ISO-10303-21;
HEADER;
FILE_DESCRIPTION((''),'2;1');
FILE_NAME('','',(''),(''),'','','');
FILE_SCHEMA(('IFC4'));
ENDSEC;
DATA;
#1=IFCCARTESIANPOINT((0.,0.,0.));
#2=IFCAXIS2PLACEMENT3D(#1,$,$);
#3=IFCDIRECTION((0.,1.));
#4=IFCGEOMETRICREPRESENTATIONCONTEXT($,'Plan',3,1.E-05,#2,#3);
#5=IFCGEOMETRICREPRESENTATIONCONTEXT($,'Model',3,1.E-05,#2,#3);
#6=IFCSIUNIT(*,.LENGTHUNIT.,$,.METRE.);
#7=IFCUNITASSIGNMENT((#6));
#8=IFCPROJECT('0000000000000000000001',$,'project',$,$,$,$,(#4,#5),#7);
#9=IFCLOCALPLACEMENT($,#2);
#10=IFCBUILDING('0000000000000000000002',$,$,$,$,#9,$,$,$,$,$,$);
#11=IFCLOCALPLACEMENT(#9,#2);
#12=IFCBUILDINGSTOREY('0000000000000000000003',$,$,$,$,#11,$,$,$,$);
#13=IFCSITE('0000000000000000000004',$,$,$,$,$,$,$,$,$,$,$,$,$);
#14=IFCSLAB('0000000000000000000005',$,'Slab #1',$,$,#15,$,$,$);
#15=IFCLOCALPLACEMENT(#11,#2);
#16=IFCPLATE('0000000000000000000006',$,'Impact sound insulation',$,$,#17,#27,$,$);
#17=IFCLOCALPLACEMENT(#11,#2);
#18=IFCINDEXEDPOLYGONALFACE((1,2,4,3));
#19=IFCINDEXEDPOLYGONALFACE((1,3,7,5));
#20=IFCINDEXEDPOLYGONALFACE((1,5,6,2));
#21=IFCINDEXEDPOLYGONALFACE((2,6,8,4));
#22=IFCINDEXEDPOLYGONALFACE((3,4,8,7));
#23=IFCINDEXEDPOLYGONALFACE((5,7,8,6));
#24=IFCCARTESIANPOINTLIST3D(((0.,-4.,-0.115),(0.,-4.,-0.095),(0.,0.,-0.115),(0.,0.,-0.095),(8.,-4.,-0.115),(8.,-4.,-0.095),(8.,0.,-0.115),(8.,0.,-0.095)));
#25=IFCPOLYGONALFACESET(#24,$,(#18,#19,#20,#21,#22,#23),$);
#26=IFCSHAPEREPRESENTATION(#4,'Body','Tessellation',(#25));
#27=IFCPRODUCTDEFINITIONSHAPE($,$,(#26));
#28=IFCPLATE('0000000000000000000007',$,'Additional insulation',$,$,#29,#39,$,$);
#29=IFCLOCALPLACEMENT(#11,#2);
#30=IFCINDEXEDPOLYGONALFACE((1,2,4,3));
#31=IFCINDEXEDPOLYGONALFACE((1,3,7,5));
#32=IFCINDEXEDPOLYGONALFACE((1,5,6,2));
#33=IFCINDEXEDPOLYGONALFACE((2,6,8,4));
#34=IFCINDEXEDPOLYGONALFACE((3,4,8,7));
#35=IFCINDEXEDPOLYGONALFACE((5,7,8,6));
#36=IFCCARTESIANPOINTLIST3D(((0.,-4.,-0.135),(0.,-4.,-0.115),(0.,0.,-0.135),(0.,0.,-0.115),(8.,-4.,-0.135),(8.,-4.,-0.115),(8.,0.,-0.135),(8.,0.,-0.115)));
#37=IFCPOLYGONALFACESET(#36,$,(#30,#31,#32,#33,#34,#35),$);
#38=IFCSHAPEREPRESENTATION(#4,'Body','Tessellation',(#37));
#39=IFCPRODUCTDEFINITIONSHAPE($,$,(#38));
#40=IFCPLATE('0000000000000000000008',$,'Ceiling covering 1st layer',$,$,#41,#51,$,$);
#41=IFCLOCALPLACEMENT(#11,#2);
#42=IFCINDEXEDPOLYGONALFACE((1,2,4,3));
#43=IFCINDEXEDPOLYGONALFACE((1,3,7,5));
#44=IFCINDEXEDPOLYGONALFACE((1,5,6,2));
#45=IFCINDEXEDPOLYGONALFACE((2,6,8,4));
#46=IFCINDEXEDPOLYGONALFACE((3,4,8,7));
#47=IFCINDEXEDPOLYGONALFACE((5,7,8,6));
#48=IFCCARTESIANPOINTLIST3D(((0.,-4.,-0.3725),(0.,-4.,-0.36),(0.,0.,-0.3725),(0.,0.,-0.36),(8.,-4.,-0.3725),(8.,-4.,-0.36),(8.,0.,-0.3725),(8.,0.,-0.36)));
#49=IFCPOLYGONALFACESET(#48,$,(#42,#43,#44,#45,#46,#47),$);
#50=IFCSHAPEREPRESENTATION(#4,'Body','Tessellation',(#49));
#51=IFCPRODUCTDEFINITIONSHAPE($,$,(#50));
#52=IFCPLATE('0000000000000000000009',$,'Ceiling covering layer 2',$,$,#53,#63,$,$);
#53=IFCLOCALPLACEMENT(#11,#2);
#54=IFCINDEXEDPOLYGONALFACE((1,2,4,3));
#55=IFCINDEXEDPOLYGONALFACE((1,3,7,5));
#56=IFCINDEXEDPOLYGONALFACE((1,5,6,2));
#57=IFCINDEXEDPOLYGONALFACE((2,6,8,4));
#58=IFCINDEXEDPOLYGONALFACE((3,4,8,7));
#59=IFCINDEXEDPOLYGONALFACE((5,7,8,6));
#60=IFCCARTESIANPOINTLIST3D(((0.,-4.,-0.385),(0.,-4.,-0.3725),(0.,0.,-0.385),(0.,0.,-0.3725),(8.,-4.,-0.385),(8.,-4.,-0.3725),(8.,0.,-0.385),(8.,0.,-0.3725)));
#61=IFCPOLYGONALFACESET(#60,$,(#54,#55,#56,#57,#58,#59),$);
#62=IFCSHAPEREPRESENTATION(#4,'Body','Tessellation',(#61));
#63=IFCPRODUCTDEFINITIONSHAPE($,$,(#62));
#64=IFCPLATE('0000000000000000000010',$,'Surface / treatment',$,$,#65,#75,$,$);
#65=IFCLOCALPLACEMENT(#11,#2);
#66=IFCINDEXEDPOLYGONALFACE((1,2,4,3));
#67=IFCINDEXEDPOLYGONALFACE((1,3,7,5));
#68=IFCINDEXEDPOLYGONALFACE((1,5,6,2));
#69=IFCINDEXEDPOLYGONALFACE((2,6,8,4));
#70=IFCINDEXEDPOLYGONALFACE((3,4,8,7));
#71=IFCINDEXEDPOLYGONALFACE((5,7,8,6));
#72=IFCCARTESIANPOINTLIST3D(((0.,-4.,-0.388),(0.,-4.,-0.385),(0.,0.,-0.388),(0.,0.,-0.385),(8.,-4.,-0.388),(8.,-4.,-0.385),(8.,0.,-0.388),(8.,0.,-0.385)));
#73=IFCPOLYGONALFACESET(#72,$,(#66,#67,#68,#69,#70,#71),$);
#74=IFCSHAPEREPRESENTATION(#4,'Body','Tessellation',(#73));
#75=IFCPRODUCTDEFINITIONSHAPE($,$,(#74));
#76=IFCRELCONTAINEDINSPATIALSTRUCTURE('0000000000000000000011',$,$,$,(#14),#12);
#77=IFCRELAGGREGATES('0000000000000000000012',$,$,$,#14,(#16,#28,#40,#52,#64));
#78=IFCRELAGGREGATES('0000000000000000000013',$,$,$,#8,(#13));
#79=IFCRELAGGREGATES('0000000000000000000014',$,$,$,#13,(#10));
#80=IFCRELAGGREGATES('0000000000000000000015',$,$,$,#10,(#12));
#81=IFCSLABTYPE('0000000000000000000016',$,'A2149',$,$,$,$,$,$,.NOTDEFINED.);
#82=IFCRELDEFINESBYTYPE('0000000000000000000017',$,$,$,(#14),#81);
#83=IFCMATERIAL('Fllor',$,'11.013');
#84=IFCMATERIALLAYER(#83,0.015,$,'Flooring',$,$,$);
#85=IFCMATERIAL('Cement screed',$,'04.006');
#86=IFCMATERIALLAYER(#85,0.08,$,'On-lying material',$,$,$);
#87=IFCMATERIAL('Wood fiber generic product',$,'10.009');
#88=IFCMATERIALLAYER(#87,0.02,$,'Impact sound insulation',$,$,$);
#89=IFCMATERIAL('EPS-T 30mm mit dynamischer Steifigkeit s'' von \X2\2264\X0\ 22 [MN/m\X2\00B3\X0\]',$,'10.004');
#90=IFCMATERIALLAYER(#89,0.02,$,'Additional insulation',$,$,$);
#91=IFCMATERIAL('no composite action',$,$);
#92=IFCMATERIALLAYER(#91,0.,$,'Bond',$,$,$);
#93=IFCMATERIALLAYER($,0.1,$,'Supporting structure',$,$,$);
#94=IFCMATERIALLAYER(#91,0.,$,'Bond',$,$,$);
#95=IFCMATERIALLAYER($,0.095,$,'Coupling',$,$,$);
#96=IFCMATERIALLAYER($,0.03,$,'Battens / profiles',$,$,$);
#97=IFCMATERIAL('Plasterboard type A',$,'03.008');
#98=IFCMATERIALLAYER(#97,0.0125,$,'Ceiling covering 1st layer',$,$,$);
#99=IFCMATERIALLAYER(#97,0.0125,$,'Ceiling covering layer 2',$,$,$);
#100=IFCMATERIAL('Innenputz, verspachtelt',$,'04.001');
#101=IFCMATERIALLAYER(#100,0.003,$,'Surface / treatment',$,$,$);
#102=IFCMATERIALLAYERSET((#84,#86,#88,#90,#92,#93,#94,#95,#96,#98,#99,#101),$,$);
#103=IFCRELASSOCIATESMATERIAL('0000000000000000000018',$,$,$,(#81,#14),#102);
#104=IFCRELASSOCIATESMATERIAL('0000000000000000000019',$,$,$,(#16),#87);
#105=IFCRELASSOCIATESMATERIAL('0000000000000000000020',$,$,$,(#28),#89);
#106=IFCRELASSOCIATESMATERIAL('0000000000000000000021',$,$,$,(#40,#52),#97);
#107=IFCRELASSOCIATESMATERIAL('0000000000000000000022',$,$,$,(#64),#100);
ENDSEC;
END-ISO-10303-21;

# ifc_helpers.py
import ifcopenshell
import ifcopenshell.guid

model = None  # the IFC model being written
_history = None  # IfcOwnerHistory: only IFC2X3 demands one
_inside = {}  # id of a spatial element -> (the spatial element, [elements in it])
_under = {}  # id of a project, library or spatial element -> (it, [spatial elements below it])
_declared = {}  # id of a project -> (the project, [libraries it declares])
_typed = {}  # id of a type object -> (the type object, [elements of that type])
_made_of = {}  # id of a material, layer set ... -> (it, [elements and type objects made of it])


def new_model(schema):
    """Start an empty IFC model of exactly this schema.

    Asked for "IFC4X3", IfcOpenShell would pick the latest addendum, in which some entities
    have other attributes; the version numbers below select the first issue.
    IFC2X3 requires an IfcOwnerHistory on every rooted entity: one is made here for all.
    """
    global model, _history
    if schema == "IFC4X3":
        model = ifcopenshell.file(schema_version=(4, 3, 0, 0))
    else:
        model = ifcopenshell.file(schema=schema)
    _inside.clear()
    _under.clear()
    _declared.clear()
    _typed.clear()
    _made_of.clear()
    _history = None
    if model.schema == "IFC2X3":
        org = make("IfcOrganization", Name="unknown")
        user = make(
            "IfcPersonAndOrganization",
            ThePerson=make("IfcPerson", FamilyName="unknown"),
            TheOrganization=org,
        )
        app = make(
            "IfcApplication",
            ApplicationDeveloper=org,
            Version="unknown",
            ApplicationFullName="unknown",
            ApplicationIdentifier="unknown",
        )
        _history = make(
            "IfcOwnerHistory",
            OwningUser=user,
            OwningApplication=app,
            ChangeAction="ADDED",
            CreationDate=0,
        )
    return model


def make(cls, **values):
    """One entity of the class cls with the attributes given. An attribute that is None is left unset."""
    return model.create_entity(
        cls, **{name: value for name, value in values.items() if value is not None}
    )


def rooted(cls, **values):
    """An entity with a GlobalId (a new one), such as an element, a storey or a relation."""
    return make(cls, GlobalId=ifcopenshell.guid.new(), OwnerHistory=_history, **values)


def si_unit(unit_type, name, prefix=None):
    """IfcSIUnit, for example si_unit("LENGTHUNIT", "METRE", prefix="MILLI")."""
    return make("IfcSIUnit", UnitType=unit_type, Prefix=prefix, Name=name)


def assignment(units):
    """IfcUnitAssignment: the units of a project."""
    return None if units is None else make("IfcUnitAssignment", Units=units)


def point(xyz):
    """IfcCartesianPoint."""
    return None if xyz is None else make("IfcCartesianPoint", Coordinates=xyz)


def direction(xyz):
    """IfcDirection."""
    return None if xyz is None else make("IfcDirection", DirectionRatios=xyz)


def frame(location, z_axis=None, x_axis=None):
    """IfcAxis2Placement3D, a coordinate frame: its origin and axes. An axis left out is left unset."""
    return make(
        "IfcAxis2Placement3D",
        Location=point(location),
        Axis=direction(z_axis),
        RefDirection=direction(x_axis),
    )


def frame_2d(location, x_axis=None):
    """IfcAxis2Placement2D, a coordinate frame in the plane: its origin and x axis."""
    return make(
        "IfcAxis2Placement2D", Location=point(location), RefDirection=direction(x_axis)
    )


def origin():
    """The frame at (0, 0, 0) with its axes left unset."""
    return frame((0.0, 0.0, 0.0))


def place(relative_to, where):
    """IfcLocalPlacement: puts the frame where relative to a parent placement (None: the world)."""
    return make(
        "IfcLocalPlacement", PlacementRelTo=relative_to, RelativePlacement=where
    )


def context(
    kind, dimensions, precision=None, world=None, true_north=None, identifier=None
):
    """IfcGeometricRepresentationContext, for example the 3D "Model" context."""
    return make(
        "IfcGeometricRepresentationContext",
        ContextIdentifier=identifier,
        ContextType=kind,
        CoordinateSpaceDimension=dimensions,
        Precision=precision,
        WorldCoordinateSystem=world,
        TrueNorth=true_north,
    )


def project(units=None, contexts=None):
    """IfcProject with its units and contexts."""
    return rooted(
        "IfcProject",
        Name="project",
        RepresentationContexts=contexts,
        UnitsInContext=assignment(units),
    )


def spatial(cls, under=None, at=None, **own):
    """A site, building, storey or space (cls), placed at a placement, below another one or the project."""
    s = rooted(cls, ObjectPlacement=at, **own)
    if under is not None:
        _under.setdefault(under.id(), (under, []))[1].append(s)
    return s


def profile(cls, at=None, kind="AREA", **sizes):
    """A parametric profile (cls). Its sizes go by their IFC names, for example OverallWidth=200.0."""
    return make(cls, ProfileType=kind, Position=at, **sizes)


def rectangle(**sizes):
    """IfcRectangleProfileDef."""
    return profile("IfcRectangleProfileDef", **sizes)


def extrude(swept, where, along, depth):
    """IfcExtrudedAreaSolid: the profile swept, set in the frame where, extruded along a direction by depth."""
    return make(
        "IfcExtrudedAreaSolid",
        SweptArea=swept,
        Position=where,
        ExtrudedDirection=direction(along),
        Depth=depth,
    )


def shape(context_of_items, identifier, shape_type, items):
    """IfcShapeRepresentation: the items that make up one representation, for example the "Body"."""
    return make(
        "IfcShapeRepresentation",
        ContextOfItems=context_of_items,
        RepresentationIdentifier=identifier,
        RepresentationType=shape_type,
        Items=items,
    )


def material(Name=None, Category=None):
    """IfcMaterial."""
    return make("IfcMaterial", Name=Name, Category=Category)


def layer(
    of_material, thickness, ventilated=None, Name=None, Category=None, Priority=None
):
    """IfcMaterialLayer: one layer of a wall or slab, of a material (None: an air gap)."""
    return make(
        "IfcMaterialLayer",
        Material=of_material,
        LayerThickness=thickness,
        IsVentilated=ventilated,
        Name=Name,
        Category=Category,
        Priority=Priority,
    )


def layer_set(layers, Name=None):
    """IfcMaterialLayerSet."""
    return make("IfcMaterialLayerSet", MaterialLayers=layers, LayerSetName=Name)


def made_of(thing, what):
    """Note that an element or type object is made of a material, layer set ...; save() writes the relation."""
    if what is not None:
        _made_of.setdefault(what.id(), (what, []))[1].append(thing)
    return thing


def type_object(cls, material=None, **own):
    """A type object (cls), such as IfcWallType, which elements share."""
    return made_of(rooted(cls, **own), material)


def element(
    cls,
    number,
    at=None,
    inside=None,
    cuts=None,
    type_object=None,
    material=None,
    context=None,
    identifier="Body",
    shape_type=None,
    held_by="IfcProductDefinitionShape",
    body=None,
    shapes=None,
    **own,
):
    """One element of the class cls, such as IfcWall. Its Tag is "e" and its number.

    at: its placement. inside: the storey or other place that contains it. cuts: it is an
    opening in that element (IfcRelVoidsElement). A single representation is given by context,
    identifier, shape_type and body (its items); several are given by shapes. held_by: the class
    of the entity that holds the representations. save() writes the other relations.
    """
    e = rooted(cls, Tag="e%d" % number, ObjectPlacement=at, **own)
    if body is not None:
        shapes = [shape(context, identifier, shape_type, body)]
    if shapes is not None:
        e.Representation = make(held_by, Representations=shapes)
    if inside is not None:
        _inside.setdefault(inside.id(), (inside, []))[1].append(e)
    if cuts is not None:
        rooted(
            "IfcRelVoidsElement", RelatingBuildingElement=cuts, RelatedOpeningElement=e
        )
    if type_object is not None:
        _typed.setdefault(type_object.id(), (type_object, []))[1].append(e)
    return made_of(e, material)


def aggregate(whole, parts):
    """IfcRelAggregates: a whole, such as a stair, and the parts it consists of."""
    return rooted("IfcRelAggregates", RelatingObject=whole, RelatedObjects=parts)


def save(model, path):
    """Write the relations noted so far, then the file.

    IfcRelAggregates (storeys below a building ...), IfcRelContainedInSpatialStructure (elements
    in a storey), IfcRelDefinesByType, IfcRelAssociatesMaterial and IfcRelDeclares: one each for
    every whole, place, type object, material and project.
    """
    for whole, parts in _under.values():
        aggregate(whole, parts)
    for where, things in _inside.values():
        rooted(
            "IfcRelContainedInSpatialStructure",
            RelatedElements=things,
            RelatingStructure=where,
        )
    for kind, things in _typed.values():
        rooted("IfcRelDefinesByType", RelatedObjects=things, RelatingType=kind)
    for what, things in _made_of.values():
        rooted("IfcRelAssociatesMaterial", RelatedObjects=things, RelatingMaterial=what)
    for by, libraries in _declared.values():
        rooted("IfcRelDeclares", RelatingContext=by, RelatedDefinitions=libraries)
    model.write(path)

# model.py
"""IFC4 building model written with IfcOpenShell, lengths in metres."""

from ifc_helpers import new_model, si_unit, direction, frame, frame_2d, origin, place, context, project, spatial, rectangle, extrude, material, layer, layer_set, type_object, element, aggregate, save


model = new_model("IFC4")

# Units and contexts
plan_context = context("Plan", 3, precision=1e-05, world=origin(), true_north=direction((0.0, 1.0)))
model_context = context("Model", 3, precision=1e-05, world=origin(), true_north=direction((0.0, 1.0)))
ifc_project = project(units=[si_unit("LENGTHUNIT", "METRE")], contexts=[plan_context, model_context])

# Site, building, storey
site = spatial("IfcSite", under=ifc_project)
building_placement = place(None, origin())
building = spatial("IfcBuilding", under=site, at=building_placement)
storey_placement = place(building_placement, origin())
storey = spatial("IfcBuildingStorey", under=building, at=storey_placement)

# Slab, plates
ifc_material_1 = material(Name="Fllor", Category="11.013")
ifc_layer_1 = layer(ifc_material_1, 0.015, Name="Flooring")
ifc_material_2 = material(Name="Cement screed", Category="04.006")
ifc_layer_2 = layer(ifc_material_2, 0.08, Name="On-lying material")
ifc_material_3 = material(Name="Wood fiber generic product", Category="10.009")
ifc_layer_3 = layer(ifc_material_3, 0.02, Name="Impact sound insulation")
ifc_material_4 = material(Name="EPS-T 30mm mit dynamischer Steifigkeit s' von ≤ 22 [MN/m³]", Category="10.004")
ifc_layer_4 = layer(ifc_material_4, 0.02, Name="Additional insulation")
ifc_material_5 = material(Name="no composite action")
ifc_layer_5 = layer(ifc_material_5, 0.0, Name="Bond")
ifc_layer_6 = layer(None, 0.1, Name="Supporting structure")
ifc_layer_7 = layer(ifc_material_5, 0.0, Name="Bond")
ifc_layer_8 = layer(None, 0.095, Name="Coupling")
ifc_layer_9 = layer(None, 0.03, Name="Battens / profiles")
ifc_material_6 = material(Name="Plasterboard type A", Category="03.008")
ifc_layer_10 = layer(ifc_material_6, 0.0125, Name="Ceiling covering 1st layer")
ifc_layer_11 = layer(ifc_material_6, 0.0125, Name="Ceiling covering layer 2")
ifc_material_7 = material(Name="Innenputz, verspachtelt", Category="04.001")
ifc_layer_12 = layer(ifc_material_7, 0.003, Name="Surface / treatment")
ifc_layer_set = layer_set([ifc_layer_1, ifc_layer_2, ifc_layer_3, ifc_layer_4, ifc_layer_5, ifc_layer_6, ifc_layer_7, ifc_layer_8, ifc_layer_9, ifc_layer_10, ifc_layer_11, ifc_layer_12])
slab_type = type_object("IfcSlabType", Name="A2149", PredefinedType="NOTDEFINED", material=ifc_layer_set)
slab_placement = place(None, frame((0.0, 0.0, 0.0), z_axis=(0.0, 0.0, -1.0), x_axis=(1.0, 0.0, 0.0)))
slab = element("IfcSlab", 1, at=slab_placement, inside=storey, type_object=slab_type, material=ifc_layer_set, Name="Slab #1")
plate_1_placement = place(slab_placement, origin())
plate_1 = element("IfcPlate", 2, at=plate_1_placement, material=ifc_material_3, Name="Impact sound insulation", context=plan_context, shape_type="SweptSolid", body=[
    extrude(rectangle(XDim=8.0, YDim=4.0, at=frame_2d((4.0, 2.0), x_axis=(1.0, 0.0))), frame((0.0, 0.0, 0.095), z_axis=(0.0, 0.0, 1.0), x_axis=(1.0, 0.0, 0.0)), (0.0, 0.0, 1.0), 0.02),
])
plate_2_placement = place(slab_placement, origin())
plate_2 = element("IfcPlate", 3, at=plate_2_placement, material=ifc_material_4, Name="Additional insulation", context=plan_context, shape_type="SweptSolid", body=[
    extrude(rectangle(XDim=8.0, YDim=4.0, at=frame_2d((4.0, 2.0), x_axis=(1.0, 0.0))), frame((0.0, 0.0, 0.115), z_axis=(0.0, 0.0, 1.0), x_axis=(1.0, 0.0, 0.0)), (0.0, 0.0, 1.0), 0.02),
])
plate_3_placement = place(slab_placement, origin())
plate_3 = element("IfcPlate", 4, at=plate_3_placement, material=ifc_material_6, Name="Ceiling covering 1st layer", context=plan_context, shape_type="SweptSolid", body=[
    extrude(rectangle(XDim=8.0, YDim=4.0, at=frame_2d((4.0, 2.0), x_axis=(1.0, 0.0))), frame((0.0, 0.0, 0.36), z_axis=(0.0, 0.0, 1.0), x_axis=(1.0, 0.0, 0.0)), (0.0, 0.0, 1.0), 0.0125),
])
plate_4_placement = place(slab_placement, origin())
plate_4 = element("IfcPlate", 5, at=plate_4_placement, material=ifc_material_6, Name="Ceiling covering layer 2", context=plan_context, shape_type="SweptSolid", body=[
    extrude(rectangle(XDim=8.0, YDim=4.0, at=frame_2d((4.0, 2.0), x_axis=(1.0, 0.0))), frame((0.0, 0.0, 0.3725), z_axis=(0.0, 0.0, 1.0), x_axis=(1.0, 0.0, 0.0)), (0.0, 0.0, 1.0), 0.0125),
])
plate_5_placement = place(slab_placement, origin())
plate_5 = element("IfcPlate", 6, at=plate_5_placement, material=ifc_material_7, Name="Surface / treatment", context=plan_context, shape_type="SweptSolid", body=[
    extrude(rectangle(XDim=8.0, YDim=4.0, at=frame_2d((4.0, 2.0), x_axis=(1.0, 0.0))), frame((0.0, 0.0, 0.385), z_axis=(0.0, 0.0, 1.0), x_axis=(1.0, 0.0, 0.0)), (0.0, 0.0, 1.0), 0.003),
])
aggregate(slab, [plate_1, plate_2, plate_3, plate_4, plate_5])

save(model, "model.ifc")
